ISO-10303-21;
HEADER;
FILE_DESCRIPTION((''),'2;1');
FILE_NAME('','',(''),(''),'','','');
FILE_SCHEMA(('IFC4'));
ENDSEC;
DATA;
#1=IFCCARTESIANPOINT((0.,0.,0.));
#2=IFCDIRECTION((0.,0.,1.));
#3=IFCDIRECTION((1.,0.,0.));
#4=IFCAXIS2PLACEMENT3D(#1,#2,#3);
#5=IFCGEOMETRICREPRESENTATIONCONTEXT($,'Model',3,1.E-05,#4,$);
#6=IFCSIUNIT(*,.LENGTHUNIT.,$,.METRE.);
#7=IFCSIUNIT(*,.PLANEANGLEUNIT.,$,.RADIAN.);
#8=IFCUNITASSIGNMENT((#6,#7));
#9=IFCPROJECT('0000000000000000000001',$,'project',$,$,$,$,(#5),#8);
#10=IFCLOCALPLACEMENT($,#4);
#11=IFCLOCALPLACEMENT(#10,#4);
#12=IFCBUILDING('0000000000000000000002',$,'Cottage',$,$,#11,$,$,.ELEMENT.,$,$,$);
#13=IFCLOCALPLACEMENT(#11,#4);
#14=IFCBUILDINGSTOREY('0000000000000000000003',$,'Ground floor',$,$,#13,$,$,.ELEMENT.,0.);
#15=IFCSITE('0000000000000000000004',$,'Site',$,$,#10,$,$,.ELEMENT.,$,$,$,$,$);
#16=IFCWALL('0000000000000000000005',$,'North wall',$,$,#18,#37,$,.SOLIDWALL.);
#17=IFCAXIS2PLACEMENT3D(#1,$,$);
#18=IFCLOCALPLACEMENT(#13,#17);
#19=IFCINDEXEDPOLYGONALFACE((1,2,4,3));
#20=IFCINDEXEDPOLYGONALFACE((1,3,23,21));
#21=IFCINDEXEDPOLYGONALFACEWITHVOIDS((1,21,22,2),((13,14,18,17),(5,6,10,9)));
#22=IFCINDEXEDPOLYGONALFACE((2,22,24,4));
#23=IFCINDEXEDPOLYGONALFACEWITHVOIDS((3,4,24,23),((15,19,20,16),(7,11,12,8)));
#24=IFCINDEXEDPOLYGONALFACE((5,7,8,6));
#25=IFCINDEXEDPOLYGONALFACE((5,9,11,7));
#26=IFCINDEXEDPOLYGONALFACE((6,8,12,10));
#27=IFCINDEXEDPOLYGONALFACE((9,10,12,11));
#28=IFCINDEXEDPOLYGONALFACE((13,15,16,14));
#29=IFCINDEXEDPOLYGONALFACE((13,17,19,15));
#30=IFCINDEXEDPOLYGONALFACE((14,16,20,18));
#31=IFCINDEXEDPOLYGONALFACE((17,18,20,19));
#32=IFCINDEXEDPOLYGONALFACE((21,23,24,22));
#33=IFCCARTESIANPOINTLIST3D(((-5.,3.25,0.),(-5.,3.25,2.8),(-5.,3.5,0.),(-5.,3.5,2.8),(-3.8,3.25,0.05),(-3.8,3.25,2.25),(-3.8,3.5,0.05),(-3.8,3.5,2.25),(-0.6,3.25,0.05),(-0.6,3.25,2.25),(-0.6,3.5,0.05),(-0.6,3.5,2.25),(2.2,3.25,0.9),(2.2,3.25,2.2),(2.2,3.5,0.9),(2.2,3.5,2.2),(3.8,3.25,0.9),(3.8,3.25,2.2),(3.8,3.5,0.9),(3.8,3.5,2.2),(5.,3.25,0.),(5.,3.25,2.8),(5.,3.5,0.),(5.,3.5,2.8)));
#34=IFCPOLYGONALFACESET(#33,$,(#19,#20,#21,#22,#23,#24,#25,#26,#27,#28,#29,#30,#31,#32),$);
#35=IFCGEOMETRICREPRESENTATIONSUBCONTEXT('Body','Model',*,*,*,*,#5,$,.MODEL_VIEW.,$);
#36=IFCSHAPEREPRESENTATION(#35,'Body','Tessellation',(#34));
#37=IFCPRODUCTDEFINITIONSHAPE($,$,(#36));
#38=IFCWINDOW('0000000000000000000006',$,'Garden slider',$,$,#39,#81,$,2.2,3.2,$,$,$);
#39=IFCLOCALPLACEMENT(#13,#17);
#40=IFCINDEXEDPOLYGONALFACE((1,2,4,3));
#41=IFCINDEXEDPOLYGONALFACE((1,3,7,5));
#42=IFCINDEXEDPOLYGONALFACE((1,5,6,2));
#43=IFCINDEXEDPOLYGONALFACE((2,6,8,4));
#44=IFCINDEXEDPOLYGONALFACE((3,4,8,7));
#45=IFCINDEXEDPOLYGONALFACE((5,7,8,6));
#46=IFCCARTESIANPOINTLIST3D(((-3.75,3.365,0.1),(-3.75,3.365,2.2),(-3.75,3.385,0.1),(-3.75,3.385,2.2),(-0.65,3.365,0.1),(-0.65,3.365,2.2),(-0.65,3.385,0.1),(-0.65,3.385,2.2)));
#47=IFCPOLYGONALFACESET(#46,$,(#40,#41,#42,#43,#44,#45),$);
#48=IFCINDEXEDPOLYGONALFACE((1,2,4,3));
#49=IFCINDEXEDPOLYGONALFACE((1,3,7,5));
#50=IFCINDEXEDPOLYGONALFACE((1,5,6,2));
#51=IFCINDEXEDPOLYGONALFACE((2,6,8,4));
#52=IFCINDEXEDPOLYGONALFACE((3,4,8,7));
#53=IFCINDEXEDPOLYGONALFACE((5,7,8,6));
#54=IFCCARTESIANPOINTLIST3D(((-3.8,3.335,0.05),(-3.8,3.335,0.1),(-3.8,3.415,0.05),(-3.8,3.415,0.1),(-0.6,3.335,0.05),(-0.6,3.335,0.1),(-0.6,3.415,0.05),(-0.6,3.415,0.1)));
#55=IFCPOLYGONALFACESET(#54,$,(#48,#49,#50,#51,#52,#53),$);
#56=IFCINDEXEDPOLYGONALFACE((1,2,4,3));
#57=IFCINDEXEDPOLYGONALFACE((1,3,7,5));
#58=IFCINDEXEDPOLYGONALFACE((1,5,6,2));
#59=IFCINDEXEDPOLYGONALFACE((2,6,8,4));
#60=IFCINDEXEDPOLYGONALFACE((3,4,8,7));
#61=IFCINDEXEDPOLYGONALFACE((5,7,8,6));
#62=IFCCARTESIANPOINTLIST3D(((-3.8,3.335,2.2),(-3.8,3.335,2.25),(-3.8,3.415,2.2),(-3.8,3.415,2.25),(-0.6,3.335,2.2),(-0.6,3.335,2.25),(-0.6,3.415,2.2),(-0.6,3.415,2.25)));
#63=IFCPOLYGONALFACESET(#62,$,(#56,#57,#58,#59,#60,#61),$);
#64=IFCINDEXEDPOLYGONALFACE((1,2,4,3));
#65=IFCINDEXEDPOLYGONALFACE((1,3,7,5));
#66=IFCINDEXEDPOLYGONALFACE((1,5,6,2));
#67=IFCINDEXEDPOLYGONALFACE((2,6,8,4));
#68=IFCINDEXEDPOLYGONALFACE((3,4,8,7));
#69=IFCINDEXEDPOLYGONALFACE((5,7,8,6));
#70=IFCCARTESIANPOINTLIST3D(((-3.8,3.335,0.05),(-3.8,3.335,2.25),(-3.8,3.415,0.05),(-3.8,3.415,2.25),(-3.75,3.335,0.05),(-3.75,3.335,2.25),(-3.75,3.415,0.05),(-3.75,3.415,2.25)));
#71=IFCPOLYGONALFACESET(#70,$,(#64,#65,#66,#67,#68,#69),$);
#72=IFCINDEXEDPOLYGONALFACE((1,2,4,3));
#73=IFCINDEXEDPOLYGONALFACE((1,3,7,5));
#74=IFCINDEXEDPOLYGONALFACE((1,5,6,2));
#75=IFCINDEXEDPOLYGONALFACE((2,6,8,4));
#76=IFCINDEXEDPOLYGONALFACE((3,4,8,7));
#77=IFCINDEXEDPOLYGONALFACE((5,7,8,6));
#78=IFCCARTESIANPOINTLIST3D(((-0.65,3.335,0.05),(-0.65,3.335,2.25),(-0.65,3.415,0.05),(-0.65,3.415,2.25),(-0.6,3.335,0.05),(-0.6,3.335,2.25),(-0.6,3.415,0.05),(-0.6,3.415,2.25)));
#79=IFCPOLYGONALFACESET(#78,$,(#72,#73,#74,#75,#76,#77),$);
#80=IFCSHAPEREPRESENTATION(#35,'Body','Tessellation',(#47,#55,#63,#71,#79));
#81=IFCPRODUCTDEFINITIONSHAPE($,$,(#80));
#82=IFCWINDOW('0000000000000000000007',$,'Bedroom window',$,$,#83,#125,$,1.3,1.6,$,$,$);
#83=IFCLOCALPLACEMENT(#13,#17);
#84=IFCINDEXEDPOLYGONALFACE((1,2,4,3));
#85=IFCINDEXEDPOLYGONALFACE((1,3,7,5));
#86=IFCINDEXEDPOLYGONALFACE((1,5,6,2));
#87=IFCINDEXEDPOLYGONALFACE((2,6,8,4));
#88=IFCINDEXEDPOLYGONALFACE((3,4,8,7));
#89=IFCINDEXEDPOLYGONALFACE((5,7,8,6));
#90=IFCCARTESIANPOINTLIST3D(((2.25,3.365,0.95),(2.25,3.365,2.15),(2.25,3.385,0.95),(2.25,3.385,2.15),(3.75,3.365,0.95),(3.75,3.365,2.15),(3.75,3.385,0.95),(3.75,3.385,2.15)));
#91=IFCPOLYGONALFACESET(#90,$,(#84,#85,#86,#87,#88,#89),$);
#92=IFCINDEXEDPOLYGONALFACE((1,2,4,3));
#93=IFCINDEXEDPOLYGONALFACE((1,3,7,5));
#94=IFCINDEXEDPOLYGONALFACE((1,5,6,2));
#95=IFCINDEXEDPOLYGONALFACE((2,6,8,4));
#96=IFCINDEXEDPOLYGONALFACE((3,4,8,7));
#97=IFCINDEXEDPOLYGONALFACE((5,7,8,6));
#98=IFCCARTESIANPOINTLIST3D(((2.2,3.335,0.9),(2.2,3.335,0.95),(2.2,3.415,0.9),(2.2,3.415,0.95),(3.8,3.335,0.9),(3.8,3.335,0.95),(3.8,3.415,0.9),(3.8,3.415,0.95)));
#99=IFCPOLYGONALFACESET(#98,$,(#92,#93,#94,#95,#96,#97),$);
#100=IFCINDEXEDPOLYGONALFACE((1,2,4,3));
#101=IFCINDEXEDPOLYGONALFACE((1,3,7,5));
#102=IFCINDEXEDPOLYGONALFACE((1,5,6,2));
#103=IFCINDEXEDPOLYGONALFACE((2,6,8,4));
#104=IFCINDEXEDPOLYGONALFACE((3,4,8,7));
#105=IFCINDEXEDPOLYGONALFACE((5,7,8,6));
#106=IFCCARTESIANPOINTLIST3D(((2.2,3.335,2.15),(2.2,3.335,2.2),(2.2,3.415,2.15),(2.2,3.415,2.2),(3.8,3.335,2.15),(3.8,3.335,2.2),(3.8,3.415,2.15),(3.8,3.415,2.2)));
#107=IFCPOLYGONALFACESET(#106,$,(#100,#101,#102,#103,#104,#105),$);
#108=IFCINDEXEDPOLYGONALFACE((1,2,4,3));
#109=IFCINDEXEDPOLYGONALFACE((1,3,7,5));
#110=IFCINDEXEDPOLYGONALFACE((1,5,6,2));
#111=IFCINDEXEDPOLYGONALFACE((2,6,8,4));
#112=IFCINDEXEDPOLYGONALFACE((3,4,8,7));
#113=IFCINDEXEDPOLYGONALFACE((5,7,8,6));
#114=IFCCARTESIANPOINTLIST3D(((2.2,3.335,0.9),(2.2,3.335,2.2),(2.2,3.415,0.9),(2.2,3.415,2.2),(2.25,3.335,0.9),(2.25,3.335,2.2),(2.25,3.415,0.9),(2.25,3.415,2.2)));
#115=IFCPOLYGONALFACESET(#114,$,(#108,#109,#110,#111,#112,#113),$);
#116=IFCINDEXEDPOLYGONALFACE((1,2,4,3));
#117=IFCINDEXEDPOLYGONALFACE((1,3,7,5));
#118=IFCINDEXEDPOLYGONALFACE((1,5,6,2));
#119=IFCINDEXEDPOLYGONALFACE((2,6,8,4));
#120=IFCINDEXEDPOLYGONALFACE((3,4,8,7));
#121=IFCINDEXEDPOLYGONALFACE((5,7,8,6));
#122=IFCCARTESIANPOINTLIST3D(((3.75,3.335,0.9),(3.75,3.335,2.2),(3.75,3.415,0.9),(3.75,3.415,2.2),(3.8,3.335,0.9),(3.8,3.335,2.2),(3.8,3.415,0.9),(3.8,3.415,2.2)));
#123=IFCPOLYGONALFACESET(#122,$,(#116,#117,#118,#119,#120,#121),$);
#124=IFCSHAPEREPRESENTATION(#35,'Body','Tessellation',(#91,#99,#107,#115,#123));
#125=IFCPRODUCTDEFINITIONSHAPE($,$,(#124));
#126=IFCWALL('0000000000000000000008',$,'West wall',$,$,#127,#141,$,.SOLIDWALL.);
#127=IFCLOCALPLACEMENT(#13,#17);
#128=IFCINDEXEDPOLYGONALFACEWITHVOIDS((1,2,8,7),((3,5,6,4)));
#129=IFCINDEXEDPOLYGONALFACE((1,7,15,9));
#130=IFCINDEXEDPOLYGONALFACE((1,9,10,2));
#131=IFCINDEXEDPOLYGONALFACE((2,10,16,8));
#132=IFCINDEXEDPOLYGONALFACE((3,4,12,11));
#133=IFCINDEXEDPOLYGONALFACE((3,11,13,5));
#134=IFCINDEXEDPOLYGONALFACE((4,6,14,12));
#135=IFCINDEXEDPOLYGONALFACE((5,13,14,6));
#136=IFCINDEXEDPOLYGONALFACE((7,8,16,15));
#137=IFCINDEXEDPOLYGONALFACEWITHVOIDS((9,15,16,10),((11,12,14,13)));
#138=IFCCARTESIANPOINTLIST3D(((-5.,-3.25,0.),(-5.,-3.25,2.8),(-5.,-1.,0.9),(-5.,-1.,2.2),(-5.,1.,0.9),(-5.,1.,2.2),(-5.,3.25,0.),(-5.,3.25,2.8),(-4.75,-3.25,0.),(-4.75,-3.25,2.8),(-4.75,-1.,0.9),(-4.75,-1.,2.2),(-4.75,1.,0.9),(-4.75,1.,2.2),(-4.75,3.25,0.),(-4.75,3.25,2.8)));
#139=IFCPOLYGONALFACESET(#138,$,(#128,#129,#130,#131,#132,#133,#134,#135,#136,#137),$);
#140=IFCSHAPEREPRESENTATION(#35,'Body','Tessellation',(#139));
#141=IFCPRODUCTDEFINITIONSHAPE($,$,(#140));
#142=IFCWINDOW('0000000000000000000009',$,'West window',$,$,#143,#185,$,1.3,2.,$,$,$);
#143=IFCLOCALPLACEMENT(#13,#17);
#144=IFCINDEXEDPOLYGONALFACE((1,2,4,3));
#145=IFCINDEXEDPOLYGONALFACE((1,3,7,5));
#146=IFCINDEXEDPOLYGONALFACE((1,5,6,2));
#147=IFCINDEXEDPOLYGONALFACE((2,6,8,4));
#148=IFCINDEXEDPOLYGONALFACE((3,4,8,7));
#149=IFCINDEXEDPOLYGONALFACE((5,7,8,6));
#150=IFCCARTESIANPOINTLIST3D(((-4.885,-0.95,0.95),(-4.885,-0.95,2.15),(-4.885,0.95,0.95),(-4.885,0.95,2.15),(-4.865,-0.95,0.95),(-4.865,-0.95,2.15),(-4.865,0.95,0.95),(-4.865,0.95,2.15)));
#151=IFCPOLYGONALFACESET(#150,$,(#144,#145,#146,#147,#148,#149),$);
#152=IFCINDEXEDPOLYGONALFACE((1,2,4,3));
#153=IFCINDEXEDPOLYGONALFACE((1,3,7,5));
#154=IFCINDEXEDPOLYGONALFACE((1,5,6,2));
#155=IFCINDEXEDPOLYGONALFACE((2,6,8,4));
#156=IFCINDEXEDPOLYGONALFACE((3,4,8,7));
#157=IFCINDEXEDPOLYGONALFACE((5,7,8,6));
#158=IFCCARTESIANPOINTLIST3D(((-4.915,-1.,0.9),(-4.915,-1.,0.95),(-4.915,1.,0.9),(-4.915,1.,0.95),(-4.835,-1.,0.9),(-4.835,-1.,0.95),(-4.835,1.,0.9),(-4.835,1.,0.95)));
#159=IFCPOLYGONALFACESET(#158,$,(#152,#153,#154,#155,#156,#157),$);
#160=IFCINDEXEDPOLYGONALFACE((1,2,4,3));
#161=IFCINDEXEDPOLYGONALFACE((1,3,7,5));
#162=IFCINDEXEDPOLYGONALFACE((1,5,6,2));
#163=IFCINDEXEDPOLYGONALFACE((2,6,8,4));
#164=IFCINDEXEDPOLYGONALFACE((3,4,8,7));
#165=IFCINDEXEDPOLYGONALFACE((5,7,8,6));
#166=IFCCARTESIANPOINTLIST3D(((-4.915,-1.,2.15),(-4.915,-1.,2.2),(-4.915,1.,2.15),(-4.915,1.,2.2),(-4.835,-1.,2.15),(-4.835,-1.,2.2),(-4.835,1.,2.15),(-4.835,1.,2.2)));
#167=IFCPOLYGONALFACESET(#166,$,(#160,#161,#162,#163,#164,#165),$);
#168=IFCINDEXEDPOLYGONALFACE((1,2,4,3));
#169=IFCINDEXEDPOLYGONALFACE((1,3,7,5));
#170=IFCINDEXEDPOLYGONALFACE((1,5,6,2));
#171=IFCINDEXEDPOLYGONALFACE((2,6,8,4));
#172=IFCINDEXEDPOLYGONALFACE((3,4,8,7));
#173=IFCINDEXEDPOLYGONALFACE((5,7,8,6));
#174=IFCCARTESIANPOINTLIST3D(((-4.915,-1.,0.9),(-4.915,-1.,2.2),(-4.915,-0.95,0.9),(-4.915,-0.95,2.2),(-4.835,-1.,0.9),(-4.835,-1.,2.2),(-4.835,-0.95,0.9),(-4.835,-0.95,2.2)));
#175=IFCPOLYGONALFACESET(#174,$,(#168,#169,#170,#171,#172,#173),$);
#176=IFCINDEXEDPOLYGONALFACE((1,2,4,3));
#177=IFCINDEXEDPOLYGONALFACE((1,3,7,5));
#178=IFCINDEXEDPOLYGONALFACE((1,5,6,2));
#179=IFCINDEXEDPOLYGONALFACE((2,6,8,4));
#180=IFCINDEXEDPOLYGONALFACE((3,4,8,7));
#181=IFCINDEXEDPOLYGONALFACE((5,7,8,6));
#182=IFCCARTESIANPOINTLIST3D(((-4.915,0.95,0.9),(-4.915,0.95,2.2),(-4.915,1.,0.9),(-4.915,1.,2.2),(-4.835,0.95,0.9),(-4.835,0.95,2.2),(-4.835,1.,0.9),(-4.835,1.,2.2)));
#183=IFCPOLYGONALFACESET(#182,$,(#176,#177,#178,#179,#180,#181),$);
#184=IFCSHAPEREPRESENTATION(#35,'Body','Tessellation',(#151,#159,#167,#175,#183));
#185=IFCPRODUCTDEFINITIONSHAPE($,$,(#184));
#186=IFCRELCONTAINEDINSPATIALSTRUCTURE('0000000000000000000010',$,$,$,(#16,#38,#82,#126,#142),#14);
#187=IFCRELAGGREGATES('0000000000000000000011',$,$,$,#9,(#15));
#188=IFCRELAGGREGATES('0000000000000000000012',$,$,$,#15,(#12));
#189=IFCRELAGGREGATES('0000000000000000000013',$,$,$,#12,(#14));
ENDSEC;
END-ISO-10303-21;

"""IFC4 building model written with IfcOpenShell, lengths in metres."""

from ifc_helpers import new_model, si_unit, frame, frame_2d, origin_with_axes, place, context, subcontext, project, spatial, rectangle, extrude, element, fill, save


model = new_model("IFC4")

# Units and contexts
model_context = context("Model", 3, precision=1e-05, world=origin_with_axes())
body_context = subcontext(model_context, "Body", "Model", "MODEL_VIEW")
ifc_project = project(units=[si_unit("LENGTHUNIT", "METRE"), si_unit("PLANEANGLEUNIT", "RADIAN")], contexts=[model_context])

# Site, building, storey
site_placement = place(None, origin_with_axes())
site = spatial("IfcSite", under=ifc_project, at=site_placement, Name="Site", CompositionType="ELEMENT")
building_placement = place(site_placement, origin_with_axes())
building = spatial("IfcBuilding", under=site, at=building_placement, Name="Cottage", CompositionType="ELEMENT")
storey_placement = place(building_placement, origin_with_axes())
storey = spatial("IfcBuildingStorey", under=building, at=storey_placement, Name="Ground floor", CompositionType="ELEMENT", Elevation=0.0)

# Wall, openings, windows
wall_1_placement = place(storey_placement, origin_with_axes())
wall_1 = element("IfcWall", 1, at=wall_1_placement, inside=storey, Name="North wall", PredefinedType="SOLIDWALL", context=body_context, shape_type="SweptSolid", body=[
    extrude(rectangle(XDim=10.0, YDim=0.25, at=frame_2d((0.0, 3.375))), origin_with_axes(), (0.0, 0.0, 1.0), 2.8),
])
opening_1_placement = place(storey_placement, origin_with_axes())
opening_1 = element("IfcOpeningElement", 2, at=opening_1_placement, cuts=wall_1, PredefinedType="OPENING", context=body_context, shape_type="SweptSolid", body=[
    extrude(rectangle(XDim=3.2, YDim=0.45, at=frame_2d((-2.2, 3.375))), frame((0.0, 0.0, 0.05), z_axis=(0.0, 0.0, 1.0), x_axis=(1.0, 0.0, 0.0)), (0.0, 0.0, 1.0), 2.2),
])
opening_2_placement = place(storey_placement, origin_with_axes())
opening_2 = element("IfcOpeningElement", 3, at=opening_2_placement, cuts=wall_1, PredefinedType="OPENING", context=body_context, shape_type="SweptSolid", body=[
    extrude(rectangle(XDim=1.6, YDim=0.45, at=frame_2d((3.0, 3.375))), frame((0.0, 0.0, 0.9), z_axis=(0.0, 0.0, 1.0), x_axis=(1.0, 0.0, 0.0)), (0.0, 0.0, 1.0), 1.3),
])
window_1_placement = place(storey_placement, origin_with_axes())
window_1 = element("IfcWindow", 4, at=window_1_placement, inside=storey, Name="Garden slider", OverallHeight=2.2, OverallWidth=3.2, context=body_context, shape_type="SweptSolid", body=[
    extrude(rectangle(XDim=3.1, YDim=0.02, at=frame_2d((-2.2, 3.375))), frame((0.0, 0.0, 0.1), z_axis=(0.0, 0.0, 1.0), x_axis=(1.0, 0.0, 0.0)), (0.0, 0.0, 1.0), 2.1),
    extrude(rectangle(XDim=3.2, YDim=0.08, at=frame_2d((-2.2, 3.375))), frame((0.0, 0.0, 0.05), z_axis=(0.0, 0.0, 1.0), x_axis=(1.0, 0.0, 0.0)), (0.0, 0.0, 1.0), 0.05),
    extrude(rectangle(XDim=3.2, YDim=0.08, at=frame_2d((-2.2, 3.375))), frame((0.0, 0.0, 2.2), z_axis=(0.0, 0.0, 1.0), x_axis=(1.0, 0.0, 0.0)), (0.0, 0.0, 1.0), 0.05),
    extrude(rectangle(XDim=0.05, YDim=0.08, at=frame_2d((-3.775, 3.375))), frame((0.0, 0.0, 0.05), z_axis=(0.0, 0.0, 1.0), x_axis=(1.0, 0.0, 0.0)), (0.0, 0.0, 1.0), 2.2),
    extrude(rectangle(XDim=0.05, YDim=0.08, at=frame_2d((-0.625, 3.375))), frame((0.0, 0.0, 0.05), z_axis=(0.0, 0.0, 1.0), x_axis=(1.0, 0.0, 0.0)), (0.0, 0.0, 1.0), 2.2),
])
fill(opening_1, window_1)
window_2_placement = place(storey_placement, origin_with_axes())
window_2 = element("IfcWindow", 5, at=window_2_placement, inside=storey, Name="Bedroom window", OverallHeight=1.3, OverallWidth=1.6, context=body_context, shape_type="SweptSolid", body=[
    extrude(rectangle(XDim=1.5, YDim=0.02, at=frame_2d((3.0, 3.375))), frame((0.0, 0.0, 0.95), z_axis=(0.0, 0.0, 1.0), x_axis=(1.0, 0.0, 0.0)), (0.0, 0.0, 1.0), 1.2),
    extrude(rectangle(XDim=1.6, YDim=0.08, at=frame_2d((3.0, 3.375))), frame((0.0, 0.0, 0.9), z_axis=(0.0, 0.0, 1.0), x_axis=(1.0, 0.0, 0.0)), (0.0, 0.0, 1.0), 0.05),
    extrude(rectangle(XDim=1.6, YDim=0.08, at=frame_2d((3.0, 3.375))), frame((0.0, 0.0, 2.15), z_axis=(0.0, 0.0, 1.0), x_axis=(1.0, 0.0, 0.0)), (0.0, 0.0, 1.0), 0.05),
    extrude(rectangle(XDim=0.05, YDim=0.08, at=frame_2d((2.225, 3.375))), frame((0.0, 0.0, 0.9), z_axis=(0.0, 0.0, 1.0), x_axis=(1.0, 0.0, 0.0)), (0.0, 0.0, 1.0), 1.3),
    extrude(rectangle(XDim=0.05, YDim=0.08, at=frame_2d((3.775, 3.375))), frame((0.0, 0.0, 0.9), z_axis=(0.0, 0.0, 1.0), x_axis=(1.0, 0.0, 0.0)), (0.0, 0.0, 1.0), 1.3),
])
fill(opening_2, window_2)

# Wall, opening, window
wall_2_placement = place(storey_placement, origin_with_axes())
wall_2 = element("IfcWall", 6, at=wall_2_placement, inside=storey, Name="West wall", PredefinedType="SOLIDWALL", context=body_context, shape_type="SweptSolid", body=[
    extrude(rectangle(XDim=0.25, YDim=6.5, at=frame_2d((-4.875, 0.0))), origin_with_axes(), (0.0, 0.0, 1.0), 2.8),
])
opening_3_placement = place(storey_placement, origin_with_axes())
opening_3 = element("IfcOpeningElement", 7, at=opening_3_placement, cuts=wall_2, PredefinedType="OPENING", context=body_context, shape_type="SweptSolid", body=[
    extrude(rectangle(XDim=0.45, YDim=2.0, at=frame_2d((-4.875, 0.0))), frame((0.0, 0.0, 0.9), z_axis=(0.0, 0.0, 1.0), x_axis=(1.0, 0.0, 0.0)), (0.0, 0.0, 1.0), 1.3),
])
window_3_placement = place(storey_placement, origin_with_axes())
window_3 = element("IfcWindow", 8, at=window_3_placement, inside=storey, Name="West window", OverallHeight=1.3, OverallWidth=2.0, context=body_context, shape_type="SweptSolid", body=[
    extrude(rectangle(XDim=0.02, YDim=1.9, at=frame_2d((-4.875, 0.0))), frame((0.0, 0.0, 0.95), z_axis=(0.0, 0.0, 1.0), x_axis=(1.0, 0.0, 0.0)), (0.0, 0.0, 1.0), 1.2),
    extrude(rectangle(XDim=0.08, YDim=2.0, at=frame_2d((-4.875, 0.0))), frame((0.0, 0.0, 0.9), z_axis=(0.0, 0.0, 1.0), x_axis=(1.0, 0.0, 0.0)), (0.0, 0.0, 1.0), 0.05),
    extrude(rectangle(XDim=0.08, YDim=2.0, at=frame_2d((-4.875, 0.0))), frame((0.0, 0.0, 2.15), z_axis=(0.0, 0.0, 1.0), x_axis=(1.0, 0.0, 0.0)), (0.0, 0.0, 1.0), 0.05),
    extrude(rectangle(XDim=0.08, YDim=0.05, at=frame_2d((-4.875, -0.975))), frame((0.0, 0.0, 0.9), z_axis=(0.0, 0.0, 1.0), x_axis=(1.0, 0.0, 0.0)), (0.0, 0.0, 1.0), 1.3),
    extrude(rectangle(XDim=0.08, YDim=0.05, at=frame_2d((-4.875, 0.975))), frame((0.0, 0.0, 0.9), z_axis=(0.0, 0.0, 1.0), x_axis=(1.0, 0.0, 0.0)), (0.0, 0.0, 1.0), 1.3),
])
fill(opening_3, window_3)

save(model, "model.ifc")
